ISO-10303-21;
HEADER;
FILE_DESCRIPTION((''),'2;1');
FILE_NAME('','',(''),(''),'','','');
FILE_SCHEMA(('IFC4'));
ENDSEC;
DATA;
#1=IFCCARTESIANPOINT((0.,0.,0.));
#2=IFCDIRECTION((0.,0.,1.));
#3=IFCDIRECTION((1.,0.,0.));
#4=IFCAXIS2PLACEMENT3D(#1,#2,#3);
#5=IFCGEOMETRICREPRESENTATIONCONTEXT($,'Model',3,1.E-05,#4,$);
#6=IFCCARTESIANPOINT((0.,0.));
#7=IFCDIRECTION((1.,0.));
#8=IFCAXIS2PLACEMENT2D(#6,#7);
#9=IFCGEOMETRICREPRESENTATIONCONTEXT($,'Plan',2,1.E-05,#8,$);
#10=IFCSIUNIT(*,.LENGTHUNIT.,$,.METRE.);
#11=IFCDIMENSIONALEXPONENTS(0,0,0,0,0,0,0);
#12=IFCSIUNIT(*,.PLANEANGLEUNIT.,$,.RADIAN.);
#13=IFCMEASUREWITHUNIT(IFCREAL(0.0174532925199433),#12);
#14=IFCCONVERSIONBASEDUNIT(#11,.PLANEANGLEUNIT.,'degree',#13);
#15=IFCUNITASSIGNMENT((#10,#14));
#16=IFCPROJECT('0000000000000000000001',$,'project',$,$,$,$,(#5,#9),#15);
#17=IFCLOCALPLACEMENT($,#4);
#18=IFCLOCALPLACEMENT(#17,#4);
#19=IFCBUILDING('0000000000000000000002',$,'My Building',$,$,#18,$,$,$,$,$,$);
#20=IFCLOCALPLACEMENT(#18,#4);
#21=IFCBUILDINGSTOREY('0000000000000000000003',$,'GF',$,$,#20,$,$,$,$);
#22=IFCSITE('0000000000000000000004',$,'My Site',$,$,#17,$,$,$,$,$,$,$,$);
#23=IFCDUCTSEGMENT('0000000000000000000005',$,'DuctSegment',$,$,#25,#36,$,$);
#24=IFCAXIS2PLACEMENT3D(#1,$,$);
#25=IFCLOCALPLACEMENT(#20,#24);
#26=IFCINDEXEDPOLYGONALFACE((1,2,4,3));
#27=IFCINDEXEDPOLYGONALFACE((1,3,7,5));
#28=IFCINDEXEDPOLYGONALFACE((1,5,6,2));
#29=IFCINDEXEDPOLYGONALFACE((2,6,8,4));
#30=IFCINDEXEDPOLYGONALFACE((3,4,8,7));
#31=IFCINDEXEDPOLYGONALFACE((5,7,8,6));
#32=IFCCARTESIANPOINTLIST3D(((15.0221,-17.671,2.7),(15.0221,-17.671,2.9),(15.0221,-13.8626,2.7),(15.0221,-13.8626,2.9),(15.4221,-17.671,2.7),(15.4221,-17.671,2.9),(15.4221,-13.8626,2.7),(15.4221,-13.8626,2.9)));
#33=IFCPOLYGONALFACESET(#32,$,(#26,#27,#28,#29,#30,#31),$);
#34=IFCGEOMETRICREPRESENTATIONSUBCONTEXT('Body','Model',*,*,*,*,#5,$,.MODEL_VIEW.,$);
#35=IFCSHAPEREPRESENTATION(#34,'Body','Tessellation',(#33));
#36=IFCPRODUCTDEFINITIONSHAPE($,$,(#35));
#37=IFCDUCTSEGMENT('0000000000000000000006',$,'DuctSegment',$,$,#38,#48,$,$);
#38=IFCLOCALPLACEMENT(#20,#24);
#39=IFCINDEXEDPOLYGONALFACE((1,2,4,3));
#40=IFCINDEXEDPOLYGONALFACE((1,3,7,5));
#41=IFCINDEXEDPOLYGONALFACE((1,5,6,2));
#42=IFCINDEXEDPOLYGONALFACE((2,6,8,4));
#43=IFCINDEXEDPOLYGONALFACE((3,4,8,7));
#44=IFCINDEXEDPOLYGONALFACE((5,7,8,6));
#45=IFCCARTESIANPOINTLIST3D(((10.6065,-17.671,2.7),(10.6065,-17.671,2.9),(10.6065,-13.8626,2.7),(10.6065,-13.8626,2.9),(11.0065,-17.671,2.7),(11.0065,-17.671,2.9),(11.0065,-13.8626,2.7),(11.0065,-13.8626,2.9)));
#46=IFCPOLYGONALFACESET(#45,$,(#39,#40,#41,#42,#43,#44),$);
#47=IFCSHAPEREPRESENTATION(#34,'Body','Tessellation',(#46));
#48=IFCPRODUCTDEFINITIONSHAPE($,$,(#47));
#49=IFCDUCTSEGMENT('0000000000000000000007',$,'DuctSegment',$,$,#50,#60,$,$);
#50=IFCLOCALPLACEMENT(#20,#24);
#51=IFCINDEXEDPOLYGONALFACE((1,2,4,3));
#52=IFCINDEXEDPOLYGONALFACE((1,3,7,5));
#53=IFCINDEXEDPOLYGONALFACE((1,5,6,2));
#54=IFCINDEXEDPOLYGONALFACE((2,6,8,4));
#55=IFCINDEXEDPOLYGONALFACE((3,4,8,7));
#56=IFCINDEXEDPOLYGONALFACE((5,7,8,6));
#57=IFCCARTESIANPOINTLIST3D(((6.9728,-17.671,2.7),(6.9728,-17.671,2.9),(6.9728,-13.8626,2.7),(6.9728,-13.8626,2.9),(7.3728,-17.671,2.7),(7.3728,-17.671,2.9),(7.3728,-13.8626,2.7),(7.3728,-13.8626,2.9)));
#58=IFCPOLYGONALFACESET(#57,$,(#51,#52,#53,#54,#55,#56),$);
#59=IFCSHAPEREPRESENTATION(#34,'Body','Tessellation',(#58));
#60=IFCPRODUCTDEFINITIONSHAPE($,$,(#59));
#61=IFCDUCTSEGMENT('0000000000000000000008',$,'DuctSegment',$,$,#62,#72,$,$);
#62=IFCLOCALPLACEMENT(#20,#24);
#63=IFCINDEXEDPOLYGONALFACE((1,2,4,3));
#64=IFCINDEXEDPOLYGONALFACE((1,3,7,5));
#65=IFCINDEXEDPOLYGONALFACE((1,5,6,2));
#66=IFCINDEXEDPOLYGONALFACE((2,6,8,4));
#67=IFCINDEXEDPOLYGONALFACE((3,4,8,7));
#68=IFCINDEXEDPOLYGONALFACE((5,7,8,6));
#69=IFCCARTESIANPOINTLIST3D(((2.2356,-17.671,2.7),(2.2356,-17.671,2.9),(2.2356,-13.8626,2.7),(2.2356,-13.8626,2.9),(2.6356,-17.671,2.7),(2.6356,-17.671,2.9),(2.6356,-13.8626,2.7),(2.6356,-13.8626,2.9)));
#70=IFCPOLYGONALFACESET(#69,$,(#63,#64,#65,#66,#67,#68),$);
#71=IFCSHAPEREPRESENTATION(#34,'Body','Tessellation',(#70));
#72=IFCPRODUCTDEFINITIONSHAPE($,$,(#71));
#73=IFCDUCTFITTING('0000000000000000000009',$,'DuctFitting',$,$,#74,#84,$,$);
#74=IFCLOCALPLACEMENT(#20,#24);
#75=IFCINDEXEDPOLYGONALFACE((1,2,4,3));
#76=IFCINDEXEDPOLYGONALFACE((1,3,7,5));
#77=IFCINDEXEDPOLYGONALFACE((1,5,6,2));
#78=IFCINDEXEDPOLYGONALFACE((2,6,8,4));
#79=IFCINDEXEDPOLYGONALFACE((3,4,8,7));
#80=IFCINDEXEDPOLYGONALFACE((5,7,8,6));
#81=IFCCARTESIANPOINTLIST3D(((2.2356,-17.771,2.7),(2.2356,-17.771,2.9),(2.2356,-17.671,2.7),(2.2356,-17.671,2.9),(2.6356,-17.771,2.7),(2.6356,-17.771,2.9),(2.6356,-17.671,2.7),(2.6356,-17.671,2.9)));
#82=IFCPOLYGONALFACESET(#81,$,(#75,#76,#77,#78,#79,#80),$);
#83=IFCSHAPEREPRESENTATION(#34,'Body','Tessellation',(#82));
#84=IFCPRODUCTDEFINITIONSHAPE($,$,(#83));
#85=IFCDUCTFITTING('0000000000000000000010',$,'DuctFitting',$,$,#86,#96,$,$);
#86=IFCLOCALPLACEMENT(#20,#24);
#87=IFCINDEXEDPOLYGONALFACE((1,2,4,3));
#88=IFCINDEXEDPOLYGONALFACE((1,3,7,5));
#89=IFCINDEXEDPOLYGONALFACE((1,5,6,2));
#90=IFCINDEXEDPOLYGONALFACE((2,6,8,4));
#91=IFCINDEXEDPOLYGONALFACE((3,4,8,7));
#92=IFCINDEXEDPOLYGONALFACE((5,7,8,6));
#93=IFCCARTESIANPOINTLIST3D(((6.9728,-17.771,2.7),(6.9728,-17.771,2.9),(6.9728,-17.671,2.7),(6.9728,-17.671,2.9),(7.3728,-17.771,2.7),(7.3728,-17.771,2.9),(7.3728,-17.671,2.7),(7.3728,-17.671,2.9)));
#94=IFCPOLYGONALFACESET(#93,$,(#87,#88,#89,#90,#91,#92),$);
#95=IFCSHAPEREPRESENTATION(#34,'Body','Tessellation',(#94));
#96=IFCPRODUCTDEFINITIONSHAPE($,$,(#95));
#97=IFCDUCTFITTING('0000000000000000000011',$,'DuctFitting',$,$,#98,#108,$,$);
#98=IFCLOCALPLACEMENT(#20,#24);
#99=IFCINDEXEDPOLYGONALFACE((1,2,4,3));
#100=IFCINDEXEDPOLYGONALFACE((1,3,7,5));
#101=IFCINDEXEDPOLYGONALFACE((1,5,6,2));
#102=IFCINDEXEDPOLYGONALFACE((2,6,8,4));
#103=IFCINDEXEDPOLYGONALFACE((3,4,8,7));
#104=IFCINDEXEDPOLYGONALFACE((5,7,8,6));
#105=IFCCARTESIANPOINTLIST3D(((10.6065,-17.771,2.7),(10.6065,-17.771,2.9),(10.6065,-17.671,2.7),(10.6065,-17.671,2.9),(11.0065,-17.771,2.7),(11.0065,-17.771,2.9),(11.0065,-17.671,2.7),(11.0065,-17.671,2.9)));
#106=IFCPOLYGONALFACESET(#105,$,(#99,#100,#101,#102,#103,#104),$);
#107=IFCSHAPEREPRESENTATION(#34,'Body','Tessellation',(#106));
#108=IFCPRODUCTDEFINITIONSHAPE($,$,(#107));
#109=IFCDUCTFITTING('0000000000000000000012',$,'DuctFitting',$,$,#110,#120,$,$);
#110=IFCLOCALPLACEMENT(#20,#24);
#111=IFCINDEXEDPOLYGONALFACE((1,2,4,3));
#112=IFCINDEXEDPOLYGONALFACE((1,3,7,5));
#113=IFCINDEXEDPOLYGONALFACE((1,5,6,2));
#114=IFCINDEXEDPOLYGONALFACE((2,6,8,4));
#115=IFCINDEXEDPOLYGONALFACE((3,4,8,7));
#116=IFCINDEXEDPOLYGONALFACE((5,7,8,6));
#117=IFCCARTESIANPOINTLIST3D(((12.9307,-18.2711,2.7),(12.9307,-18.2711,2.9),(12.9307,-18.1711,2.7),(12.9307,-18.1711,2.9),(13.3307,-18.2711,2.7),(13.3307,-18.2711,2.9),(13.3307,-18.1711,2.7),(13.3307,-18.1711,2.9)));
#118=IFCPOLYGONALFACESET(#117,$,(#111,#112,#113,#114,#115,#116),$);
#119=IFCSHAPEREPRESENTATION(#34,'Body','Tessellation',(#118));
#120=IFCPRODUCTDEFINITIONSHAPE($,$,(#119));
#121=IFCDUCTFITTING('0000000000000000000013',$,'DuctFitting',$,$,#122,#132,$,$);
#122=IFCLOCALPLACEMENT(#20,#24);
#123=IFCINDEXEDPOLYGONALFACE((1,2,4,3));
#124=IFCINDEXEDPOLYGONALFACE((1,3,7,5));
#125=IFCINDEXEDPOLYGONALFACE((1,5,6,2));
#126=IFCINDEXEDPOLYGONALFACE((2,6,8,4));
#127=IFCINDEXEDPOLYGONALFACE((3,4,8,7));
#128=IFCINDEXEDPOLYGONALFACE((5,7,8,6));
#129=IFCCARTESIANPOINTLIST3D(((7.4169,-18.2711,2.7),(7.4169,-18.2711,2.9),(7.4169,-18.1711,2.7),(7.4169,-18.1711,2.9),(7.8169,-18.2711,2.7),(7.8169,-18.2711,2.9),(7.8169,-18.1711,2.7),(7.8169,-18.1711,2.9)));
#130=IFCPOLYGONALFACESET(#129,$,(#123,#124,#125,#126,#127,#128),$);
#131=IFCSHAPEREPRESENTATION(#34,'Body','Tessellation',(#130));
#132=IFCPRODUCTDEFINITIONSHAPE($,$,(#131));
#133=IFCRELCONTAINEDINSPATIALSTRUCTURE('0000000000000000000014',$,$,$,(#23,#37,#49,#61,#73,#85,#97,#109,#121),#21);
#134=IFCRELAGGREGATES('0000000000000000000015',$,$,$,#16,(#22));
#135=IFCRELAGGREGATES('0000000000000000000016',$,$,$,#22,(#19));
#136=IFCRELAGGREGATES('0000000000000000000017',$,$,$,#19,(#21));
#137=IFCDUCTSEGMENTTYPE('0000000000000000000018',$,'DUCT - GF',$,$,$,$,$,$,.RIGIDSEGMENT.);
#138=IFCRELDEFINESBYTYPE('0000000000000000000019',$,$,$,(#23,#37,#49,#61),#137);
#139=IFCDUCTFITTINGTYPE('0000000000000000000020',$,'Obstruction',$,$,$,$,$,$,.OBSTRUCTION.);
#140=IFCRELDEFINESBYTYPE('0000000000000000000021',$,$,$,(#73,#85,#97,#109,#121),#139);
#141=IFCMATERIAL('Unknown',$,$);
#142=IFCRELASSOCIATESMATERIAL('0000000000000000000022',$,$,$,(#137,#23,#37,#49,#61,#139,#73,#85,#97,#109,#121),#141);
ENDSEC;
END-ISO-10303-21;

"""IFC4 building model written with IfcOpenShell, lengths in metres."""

from ifc_helpers import new_model, entity, si_unit, converted_unit, frame, origin_with_axes, origin_2d_with_axis, place, context, subcontext, project, spatial, rectangle, extrude, material, material_profile, profile_set, profile_usage, type_object, element, save


model = new_model("IFC4")

# Units and contexts
model_context = context("Model", 3, precision=1e-05, world=origin_with_axes())
plan_context = context("Plan", 2, precision=1e-05, world=origin_2d_with_axis())
body_context_1 = subcontext(model_context, "Body", "Model", "MODEL_VIEW")
ifc_project = project(units=[si_unit("LENGTHUNIT", "METRE"), converted_unit("PLANEANGLEUNIT", "degree", entity("IfcReal", 0.0174532925199433), si_unit("PLANEANGLEUNIT", "RADIAN"), dimensions=[0, 0, 0, 0, 0, 0, 0])], contexts=[model_context, plan_context])

# Site, building, storey
site_placement = place(None, origin_with_axes())
site = spatial("IfcSite", under=ifc_project, at=site_placement, Name="My Site")
building_placement = place(site_placement, origin_with_axes())
building = spatial("IfcBuilding", under=site, at=building_placement, Name="My Building")
storey_placement = place(building_placement, origin_with_axes())
storey = spatial("IfcBuildingStorey", under=building, at=storey_placement, Name="GF")

# Shared definitions
ifc_material = material(Name="Unknown")

# Duct segments
ifc_material_profile_1 = material_profile(ifc_material, rectangle(XDim=0.4, YDim=0.2))
ifc_profile_set_1 = profile_set([ifc_material_profile_1])
ifc_profile_usage_1 = profile_usage(ifc_profile_set_1, cardinal=5)
duct_segment_type = type_object("IfcDuctSegmentType", Name="DUCT - GF", PredefinedType="RIGIDSEGMENT", material=ifc_profile_set_1)
duct_segment_1_placement = place(storey_placement, frame((15.2221, -13.8626, 2.8), z_axis=(0.0, -1.0, 0.0), x_axis=(1.0, 0.0, 0.0)))
element("IfcDuctSegment", 1, at=duct_segment_1_placement, inside=storey, type_object=duct_segment_type, material=ifc_profile_usage_1, Name="DuctSegment", context=body_context_1, shape_type="SweptSolid", body=[
    extrude(rectangle(XDim=0.4, YDim=0.2), origin_with_axes(), (0.0, 0.0, 1.0), 3.8084),
])
ifc_profile_usage_2 = profile_usage(ifc_profile_set_1, cardinal=5)
duct_segment_2_placement = place(storey_placement, frame((10.8065, -13.8626, 2.8), z_axis=(0.0, -1.0, 0.0), x_axis=(1.0, 0.0, 0.0)))
element("IfcDuctSegment", 2, at=duct_segment_2_placement, inside=storey, type_object=duct_segment_type, material=ifc_profile_usage_2, Name="DuctSegment", context=body_context_1, shape_type="SweptSolid", body=[
    extrude(rectangle(XDim=0.4, YDim=0.2), origin_with_axes(), (0.0, 0.0, 1.0), 3.8084),
])
ifc_profile_usage_3 = profile_usage(ifc_profile_set_1, cardinal=5)
duct_segment_3_placement = place(storey_placement, frame((7.1728, -13.8626, 2.8), z_axis=(0.0, -1.0, 0.0), x_axis=(1.0, 0.0, 0.0)))
element("IfcDuctSegment", 3, at=duct_segment_3_placement, inside=storey, type_object=duct_segment_type, material=ifc_profile_usage_3, Name="DuctSegment", context=body_context_1, shape_type="SweptSolid", body=[
    extrude(rectangle(XDim=0.4, YDim=0.2), origin_with_axes(), (0.0, 0.0, 1.0), 3.8084),
])
ifc_profile_usage_4 = profile_usage(ifc_profile_set_1, cardinal=5)
duct_segment_4_placement = place(storey_placement, frame((2.4356, -13.8626, 2.8), z_axis=(0.0, -1.0, 0.0), x_axis=(1.0, 0.0, 0.0)))
element("IfcDuctSegment", 4, at=duct_segment_4_placement, inside=storey, type_object=duct_segment_type, material=ifc_profile_usage_4, Name="DuctSegment", context=body_context_1, shape_type="SweptSolid", body=[
    extrude(rectangle(XDim=0.4, YDim=0.2), origin_with_axes(), (0.0, 0.0, 1.0), 3.8084),
])

# Duct fittings
ifc_material_profile_2 = material_profile(ifc_material, rectangle(XDim=0.4, YDim=0.2))
ifc_profile_set_2 = profile_set([ifc_material_profile_2])
ifc_profile_usage_5 = profile_usage(ifc_profile_set_2, cardinal=5)
duct_fitting_type = type_object("IfcDuctFittingType", Name="Obstruction", PredefinedType="OBSTRUCTION", material=ifc_profile_set_2)
duct_fitting_1_placement = place(storey_placement, frame((2.4356, -17.671, 2.8), z_axis=(0.0, -1.0, 0.0), x_axis=(1.0, 0.0, 0.0)))
element("IfcDuctFitting", 5, at=duct_fitting_1_placement, inside=storey, type_object=duct_fitting_type, material=ifc_profile_usage_5, Name="DuctFitting", context=body_context_1, shape_type="SweptSolid", body=[
    extrude(rectangle(XDim=0.4, YDim=0.2), origin_with_axes(), (0.0, 0.0, 1.0), 0.1),
])
ifc_profile_usage_6 = profile_usage(ifc_profile_set_2, cardinal=5)
duct_fitting_2_placement = place(storey_placement, frame((7.1728, -17.671, 2.8), z_axis=(0.0, -1.0, 0.0), x_axis=(1.0, 0.0, 0.0)))
element("IfcDuctFitting", 6, at=duct_fitting_2_placement, inside=storey, type_object=duct_fitting_type, material=ifc_profile_usage_6, Name="DuctFitting", context=body_context_1, shape_type="SweptSolid", body=[
    extrude(rectangle(XDim=0.4, YDim=0.2), origin_with_axes(), (0.0, 0.0, 1.0), 0.1),
])
ifc_profile_usage_7 = profile_usage(ifc_profile_set_2, cardinal=5)
duct_fitting_3_placement = place(storey_placement, frame((10.8065, -17.671, 2.8), z_axis=(0.0, -1.0, 0.0), x_axis=(1.0, 0.0, 0.0)))
element("IfcDuctFitting", 7, at=duct_fitting_3_placement, inside=storey, type_object=duct_fitting_type, material=ifc_profile_usage_7, Name="DuctFitting", context=body_context_1, shape_type="SweptSolid", body=[
    extrude(rectangle(XDim=0.4, YDim=0.2), origin_with_axes(), (0.0, 0.0, 1.0), 0.1),
])
ifc_profile_usage_8 = profile_usage(ifc_profile_set_2, cardinal=5)
duct_fitting_4_placement = place(storey_placement, frame((13.1307, -18.2711, 2.8), z_axis=(0.0, 1.0, 0.0), x_axis=(-1.0, 0.0, 0.0)))
element("IfcDuctFitting", 8, at=duct_fitting_4_placement, inside=storey, type_object=duct_fitting_type, material=ifc_profile_usage_8, Name="DuctFitting", context=body_context_1, shape_type="SweptSolid", body=[
    extrude(rectangle(XDim=0.4, YDim=0.2), origin_with_axes(), (0.0, 0.0, 1.0), 0.1),
])
ifc_profile_usage_9 = profile_usage(ifc_profile_set_2, cardinal=5)
duct_fitting_5_placement = place(storey_placement, frame((7.6169, -18.2711, 2.8), z_axis=(0.0, 1.0, 0.0), x_axis=(-1.0, 0.0, 0.0)))
element("IfcDuctFitting", 9, at=duct_fitting_5_placement, inside=storey, type_object=duct_fitting_type, material=ifc_profile_usage_9, Name="DuctFitting", context=body_context_1, shape_type="SweptSolid", body=[
    extrude(rectangle(XDim=0.4, YDim=0.2), origin_with_axes(), (0.0, 0.0, 1.0), 0.1),
])

save(model, "model.ifc")
